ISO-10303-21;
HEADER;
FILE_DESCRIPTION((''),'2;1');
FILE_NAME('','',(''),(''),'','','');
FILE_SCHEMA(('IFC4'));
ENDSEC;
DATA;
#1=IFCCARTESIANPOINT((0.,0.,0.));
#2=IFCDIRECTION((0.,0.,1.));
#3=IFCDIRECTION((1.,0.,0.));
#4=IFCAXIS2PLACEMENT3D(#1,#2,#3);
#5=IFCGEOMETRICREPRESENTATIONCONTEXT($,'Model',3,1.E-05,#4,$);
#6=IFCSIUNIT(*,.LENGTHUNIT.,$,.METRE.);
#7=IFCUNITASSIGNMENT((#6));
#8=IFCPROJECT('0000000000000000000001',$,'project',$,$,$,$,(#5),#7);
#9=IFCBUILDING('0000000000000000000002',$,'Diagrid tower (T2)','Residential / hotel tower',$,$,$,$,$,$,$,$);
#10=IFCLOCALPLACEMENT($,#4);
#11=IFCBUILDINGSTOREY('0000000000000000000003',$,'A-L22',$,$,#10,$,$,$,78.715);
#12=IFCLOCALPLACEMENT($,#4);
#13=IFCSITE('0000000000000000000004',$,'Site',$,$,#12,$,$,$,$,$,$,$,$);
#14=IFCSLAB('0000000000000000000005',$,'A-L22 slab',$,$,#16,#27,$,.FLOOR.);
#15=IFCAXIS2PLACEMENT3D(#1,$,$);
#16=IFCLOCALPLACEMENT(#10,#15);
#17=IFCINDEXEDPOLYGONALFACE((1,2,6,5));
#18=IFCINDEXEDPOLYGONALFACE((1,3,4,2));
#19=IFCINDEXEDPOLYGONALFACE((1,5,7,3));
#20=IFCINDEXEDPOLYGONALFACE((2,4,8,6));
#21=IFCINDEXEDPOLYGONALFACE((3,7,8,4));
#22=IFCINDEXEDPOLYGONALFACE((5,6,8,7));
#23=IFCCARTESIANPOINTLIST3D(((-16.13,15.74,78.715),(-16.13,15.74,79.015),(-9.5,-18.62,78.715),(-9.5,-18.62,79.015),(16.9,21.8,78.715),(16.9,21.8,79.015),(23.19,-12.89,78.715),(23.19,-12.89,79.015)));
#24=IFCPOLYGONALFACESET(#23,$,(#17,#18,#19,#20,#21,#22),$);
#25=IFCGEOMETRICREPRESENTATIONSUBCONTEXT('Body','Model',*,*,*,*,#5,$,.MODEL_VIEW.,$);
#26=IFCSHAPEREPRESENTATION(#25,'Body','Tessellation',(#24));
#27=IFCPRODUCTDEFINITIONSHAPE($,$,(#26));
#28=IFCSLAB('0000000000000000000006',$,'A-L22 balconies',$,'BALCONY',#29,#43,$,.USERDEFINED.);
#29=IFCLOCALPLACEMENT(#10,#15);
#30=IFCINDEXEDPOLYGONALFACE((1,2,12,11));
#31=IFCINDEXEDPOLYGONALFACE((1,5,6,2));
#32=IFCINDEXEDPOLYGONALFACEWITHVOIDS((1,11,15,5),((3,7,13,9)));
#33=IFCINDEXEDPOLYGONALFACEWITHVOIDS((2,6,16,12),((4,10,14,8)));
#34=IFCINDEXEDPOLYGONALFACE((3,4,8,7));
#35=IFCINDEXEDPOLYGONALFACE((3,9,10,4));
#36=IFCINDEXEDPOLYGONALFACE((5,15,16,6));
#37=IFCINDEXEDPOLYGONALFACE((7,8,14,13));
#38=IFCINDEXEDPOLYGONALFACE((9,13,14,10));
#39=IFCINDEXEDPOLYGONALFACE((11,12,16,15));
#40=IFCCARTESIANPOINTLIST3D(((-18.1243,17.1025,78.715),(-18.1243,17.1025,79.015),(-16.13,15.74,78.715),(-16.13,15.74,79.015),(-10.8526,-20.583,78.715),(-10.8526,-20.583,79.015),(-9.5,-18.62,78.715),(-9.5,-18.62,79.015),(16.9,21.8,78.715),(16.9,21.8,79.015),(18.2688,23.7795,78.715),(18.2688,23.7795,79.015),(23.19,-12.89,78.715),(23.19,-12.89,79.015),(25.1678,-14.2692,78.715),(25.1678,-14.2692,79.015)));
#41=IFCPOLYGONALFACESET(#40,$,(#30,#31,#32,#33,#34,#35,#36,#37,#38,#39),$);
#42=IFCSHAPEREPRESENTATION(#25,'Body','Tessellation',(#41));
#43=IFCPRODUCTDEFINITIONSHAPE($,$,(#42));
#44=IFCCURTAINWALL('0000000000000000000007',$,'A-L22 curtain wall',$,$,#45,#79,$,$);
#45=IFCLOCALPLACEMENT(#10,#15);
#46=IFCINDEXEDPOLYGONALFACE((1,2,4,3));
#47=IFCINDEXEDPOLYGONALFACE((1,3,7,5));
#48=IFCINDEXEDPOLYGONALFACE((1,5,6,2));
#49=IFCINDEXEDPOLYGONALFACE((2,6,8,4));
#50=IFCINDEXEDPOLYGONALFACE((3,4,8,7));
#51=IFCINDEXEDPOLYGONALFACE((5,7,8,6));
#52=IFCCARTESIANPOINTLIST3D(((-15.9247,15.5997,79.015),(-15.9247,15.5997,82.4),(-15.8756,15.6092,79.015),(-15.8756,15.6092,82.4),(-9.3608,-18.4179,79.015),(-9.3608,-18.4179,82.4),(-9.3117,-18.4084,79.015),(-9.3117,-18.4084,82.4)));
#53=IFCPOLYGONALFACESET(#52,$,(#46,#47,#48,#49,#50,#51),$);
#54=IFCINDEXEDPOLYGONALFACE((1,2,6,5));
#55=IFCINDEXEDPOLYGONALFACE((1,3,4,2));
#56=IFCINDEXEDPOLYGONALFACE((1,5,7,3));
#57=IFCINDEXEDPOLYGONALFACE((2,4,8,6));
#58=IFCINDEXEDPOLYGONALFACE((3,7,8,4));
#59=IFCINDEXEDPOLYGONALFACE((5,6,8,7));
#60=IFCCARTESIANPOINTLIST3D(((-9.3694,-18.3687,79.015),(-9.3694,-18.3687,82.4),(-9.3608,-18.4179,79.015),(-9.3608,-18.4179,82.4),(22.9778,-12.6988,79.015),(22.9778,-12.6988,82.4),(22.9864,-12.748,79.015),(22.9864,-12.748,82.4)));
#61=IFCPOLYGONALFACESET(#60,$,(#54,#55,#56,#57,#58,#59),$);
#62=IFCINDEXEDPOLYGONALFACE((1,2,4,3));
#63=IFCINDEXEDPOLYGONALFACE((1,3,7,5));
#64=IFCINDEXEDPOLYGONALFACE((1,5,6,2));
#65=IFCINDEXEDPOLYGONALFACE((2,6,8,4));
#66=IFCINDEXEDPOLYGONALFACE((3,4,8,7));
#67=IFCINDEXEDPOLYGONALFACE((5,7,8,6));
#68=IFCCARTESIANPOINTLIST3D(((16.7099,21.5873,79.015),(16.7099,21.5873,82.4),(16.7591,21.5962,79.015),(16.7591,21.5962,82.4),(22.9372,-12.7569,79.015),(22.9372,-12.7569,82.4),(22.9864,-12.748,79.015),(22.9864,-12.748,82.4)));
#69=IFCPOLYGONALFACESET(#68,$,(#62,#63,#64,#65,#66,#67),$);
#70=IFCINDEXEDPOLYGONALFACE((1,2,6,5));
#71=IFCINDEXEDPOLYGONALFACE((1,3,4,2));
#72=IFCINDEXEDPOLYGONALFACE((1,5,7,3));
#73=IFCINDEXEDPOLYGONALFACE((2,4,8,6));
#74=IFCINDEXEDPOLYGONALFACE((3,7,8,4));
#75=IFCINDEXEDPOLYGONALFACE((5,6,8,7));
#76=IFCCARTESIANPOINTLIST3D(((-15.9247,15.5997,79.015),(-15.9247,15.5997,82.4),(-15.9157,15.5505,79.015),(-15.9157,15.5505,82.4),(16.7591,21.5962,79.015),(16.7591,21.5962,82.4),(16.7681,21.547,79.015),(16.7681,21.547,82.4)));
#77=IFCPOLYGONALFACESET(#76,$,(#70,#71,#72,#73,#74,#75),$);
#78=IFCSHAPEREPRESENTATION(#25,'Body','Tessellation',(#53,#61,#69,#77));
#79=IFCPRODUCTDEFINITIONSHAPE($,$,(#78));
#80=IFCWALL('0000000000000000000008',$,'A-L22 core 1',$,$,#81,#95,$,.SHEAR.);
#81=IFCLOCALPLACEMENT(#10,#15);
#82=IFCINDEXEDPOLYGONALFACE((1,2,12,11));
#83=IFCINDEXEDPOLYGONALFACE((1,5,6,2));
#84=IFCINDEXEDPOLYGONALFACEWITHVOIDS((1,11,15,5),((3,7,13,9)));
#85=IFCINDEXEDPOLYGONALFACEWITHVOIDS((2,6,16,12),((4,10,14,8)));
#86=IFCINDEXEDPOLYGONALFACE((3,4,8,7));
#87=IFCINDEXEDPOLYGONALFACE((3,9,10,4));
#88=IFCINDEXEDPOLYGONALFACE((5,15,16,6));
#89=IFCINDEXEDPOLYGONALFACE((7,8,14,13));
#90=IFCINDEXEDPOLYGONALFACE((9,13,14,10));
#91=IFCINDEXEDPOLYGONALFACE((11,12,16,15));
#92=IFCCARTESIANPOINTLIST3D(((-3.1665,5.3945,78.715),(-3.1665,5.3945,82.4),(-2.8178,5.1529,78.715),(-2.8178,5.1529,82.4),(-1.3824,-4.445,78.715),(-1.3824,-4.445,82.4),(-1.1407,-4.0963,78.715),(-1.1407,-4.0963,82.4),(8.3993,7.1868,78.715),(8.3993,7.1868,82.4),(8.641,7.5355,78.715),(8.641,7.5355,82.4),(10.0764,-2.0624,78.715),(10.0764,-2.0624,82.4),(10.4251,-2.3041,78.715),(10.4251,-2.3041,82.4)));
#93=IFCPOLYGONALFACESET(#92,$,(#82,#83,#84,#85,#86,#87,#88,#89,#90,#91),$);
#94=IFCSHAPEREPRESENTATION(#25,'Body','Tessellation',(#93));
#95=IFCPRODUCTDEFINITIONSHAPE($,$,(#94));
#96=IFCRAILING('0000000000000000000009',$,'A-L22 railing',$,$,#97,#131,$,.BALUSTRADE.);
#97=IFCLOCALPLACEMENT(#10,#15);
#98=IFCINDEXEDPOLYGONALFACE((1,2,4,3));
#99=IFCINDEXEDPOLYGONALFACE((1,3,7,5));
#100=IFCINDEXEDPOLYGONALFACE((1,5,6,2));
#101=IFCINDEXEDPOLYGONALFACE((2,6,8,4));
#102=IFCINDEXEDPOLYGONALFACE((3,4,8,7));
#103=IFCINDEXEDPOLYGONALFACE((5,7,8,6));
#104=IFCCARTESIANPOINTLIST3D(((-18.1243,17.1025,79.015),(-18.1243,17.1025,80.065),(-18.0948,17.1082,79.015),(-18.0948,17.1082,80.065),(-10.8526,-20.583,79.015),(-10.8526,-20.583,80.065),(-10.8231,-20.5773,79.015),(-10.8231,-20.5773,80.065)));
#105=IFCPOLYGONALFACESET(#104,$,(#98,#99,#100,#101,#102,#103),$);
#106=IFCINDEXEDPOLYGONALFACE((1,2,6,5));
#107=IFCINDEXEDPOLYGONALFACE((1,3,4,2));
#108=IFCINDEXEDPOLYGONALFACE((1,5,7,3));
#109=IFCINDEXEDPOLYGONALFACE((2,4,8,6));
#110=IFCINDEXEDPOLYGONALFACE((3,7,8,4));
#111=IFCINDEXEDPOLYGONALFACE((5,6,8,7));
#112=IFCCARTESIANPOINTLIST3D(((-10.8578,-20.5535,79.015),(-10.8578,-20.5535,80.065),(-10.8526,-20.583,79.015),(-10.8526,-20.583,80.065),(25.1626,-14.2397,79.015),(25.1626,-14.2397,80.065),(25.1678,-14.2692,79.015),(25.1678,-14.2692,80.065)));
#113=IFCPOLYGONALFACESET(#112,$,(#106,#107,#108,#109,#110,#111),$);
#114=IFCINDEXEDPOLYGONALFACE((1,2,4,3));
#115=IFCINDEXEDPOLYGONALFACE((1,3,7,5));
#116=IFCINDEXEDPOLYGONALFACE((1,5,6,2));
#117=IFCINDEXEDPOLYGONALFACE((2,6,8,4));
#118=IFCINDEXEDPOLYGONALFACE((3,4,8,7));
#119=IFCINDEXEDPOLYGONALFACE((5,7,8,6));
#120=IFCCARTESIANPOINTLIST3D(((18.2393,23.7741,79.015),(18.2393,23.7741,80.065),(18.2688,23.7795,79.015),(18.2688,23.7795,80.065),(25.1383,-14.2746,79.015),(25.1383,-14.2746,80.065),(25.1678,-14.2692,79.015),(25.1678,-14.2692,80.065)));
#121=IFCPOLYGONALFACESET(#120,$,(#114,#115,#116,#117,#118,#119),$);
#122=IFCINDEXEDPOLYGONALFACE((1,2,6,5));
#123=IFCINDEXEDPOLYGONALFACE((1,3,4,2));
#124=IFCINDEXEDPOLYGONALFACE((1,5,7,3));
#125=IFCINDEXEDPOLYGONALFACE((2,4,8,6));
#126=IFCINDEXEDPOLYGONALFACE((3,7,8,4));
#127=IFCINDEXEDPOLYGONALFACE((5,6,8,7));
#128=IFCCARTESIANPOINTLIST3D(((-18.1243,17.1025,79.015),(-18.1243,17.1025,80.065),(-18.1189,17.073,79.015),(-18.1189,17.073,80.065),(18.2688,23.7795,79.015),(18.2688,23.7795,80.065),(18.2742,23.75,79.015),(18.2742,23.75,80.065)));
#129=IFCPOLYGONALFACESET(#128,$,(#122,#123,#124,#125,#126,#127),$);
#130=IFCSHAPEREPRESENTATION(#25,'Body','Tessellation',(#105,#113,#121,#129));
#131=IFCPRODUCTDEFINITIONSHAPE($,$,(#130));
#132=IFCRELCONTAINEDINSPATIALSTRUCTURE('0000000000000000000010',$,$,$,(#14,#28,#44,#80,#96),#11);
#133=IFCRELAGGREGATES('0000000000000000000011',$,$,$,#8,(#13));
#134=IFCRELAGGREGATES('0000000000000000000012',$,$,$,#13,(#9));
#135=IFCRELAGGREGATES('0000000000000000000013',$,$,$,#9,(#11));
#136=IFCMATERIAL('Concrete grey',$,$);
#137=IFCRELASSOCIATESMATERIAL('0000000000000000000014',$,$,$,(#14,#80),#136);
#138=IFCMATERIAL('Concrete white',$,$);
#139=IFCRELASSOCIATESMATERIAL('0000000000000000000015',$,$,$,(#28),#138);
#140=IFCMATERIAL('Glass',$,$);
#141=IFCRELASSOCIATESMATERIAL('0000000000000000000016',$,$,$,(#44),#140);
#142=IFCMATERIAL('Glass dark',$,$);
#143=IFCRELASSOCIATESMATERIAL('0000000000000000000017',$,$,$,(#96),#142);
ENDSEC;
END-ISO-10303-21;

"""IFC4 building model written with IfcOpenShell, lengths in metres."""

from ifc_helpers import new_model, si_unit, frame, origin_with_axes, place, context, subcontext, project, spatial, polyline, outline, extrude, material, element, save


model = new_model("IFC4")

# Units and contexts
model_context = context("Model", 3, precision=1e-05, world=origin_with_axes())
body_context = subcontext(model_context, "Body", "Model", "MODEL_VIEW")
ifc_project = project(units=[si_unit("LENGTHUNIT", "METRE")], contexts=[model_context])

# Site, building, storey
site_placement = place(None, origin_with_axes())
site = spatial("IfcSite", under=ifc_project, at=site_placement, Name="Site")
building = spatial("IfcBuilding", under=site, Name="Diagrid tower (T2)", Description="Residential / hotel tower")
storey_placement = place(None, origin_with_axes())
storey = spatial("IfcBuildingStorey", under=building, at=storey_placement, Name="A-L22", Elevation=78.715)

# Slabs
ifc_material_1 = material(Name="Concrete grey")
slab_1_placement = place(storey_placement, origin_with_axes())
element("IfcSlab", 1, at=slab_1_placement, inside=storey, material=ifc_material_1, Name="A-L22 slab", PredefinedType="FLOOR", context=body_context, shape_type="SweptSolid", body=[
    extrude(outline(polyline([(-16.13, 15.74), (-9.5, -18.62), (23.19, -12.89), (16.9, 21.8), (-16.13, 15.74)])), frame((0.0, 0.0, 78.715), z_axis=(0.0, 0.0, 1.0), x_axis=(1.0, 0.0, 0.0)), (0.0, 0.0, 1.0), 0.3),
])
ifc_material_2 = material(Name="Concrete white")
slab_2_placement = place(storey_placement, origin_with_axes())
element("IfcSlab", 2, at=slab_2_placement, inside=storey, material=ifc_material_2, Name="A-L22 balconies", ObjectType="BALCONY", PredefinedType="USERDEFINED", context=body_context, shape_type="SweptSolid", body=[
    extrude(outline(polyline([(-18.1243, 17.1025), (-10.8526, -20.583), (25.1678, -14.2692), (18.2688, 23.7795), (-18.1243, 17.1025)]), holes=[polyline([(-16.13, 15.74), (-9.5, -18.62), (23.19, -12.89), (16.9, 21.8), (-16.13, 15.74)])]), frame((0.0, 0.0, 78.715), z_axis=(0.0, 0.0, 1.0), x_axis=(1.0, 0.0, 0.0)), (0.0, 0.0, 1.0), 0.3),
])

# Curtain wall
ifc_material_3 = material(Name="Glass")
curtain_wall_placement = place(storey_placement, origin_with_axes())
element("IfcCurtainWall", 3, at=curtain_wall_placement, inside=storey, material=ifc_material_3, Name="A-L22 curtain wall", context=body_context, shape_type="SweptSolid", body=[
    extrude(outline(polyline([(-15.9247, 15.5997), (-9.3608, -18.4179), (-9.3117, -18.4084), (-15.8756, 15.6092), (-15.9247, 15.5997)])), frame((0.0, 0.0, 79.015), z_axis=(0.0, 0.0, 1.0), x_axis=(1.0, 0.0, 0.0)), (0.0, 0.0, 1.0), 3.385),
    extrude(outline(polyline([(-9.3608, -18.4179), (22.9864, -12.748), (22.9778, -12.6988), (-9.3694, -18.3687), (-9.3608, -18.4179)])), frame((0.0, 0.0, 79.015), z_axis=(0.0, 0.0, 1.0), x_axis=(1.0, 0.0, 0.0)), (0.0, 0.0, 1.0), 3.385),
    extrude(outline(polyline([(22.9864, -12.748), (16.7591, 21.5962), (16.7099, 21.5873), (22.9372, -12.7569), (22.9864, -12.748)])), frame((0.0, 0.0, 79.015), z_axis=(0.0, 0.0, 1.0), x_axis=(1.0, 0.0, 0.0)), (0.0, 0.0, 1.0), 3.385),
    extrude(outline(polyline([(16.7591, 21.5962), (-15.9247, 15.5997), (-15.9157, 15.5505), (16.7681, 21.547), (16.7591, 21.5962)])), frame((0.0, 0.0, 79.015), z_axis=(0.0, 0.0, 1.0), x_axis=(1.0, 0.0, 0.0)), (0.0, 0.0, 1.0), 3.385),
])

# Wall
wall_placement = place(storey_placement, origin_with_axes())
element("IfcWall", 4, at=wall_placement, inside=storey, material=ifc_material_1, Name="A-L22 core 1", PredefinedType="SHEAR", context=body_context, shape_type="SweptSolid", body=[
    extrude(outline(polyline([(10.4251, -2.3041), (8.641, 7.5355), (-3.1665, 5.3945), (-1.3824, -4.445), (10.4251, -2.3041)]), holes=[polyline([(10.0764, -2.0624), (8.3993, 7.1868), (-2.8178, 5.1529), (-1.1407, -4.0963), (10.0764, -2.0624)])]), frame((0.0, 0.0, 78.715), z_axis=(0.0, 0.0, 1.0), x_axis=(1.0, 0.0, 0.0)), (0.0, 0.0, 1.0), 3.685),
])

# Railing
ifc_material_4 = material(Name="Glass dark")
railing_placement = place(storey_placement, origin_with_axes())
element("IfcRailing", 5, at=railing_placement, inside=storey, material=ifc_material_4, Name="A-L22 railing", PredefinedType="BALUSTRADE", context=body_context, shape_type="SweptSolid", body=[
    extrude(outline(polyline([(-18.1243, 17.1025), (-10.8526, -20.583), (-10.8231, -20.5773), (-18.0948, 17.1082), (-18.1243, 17.1025)])), frame((0.0, 0.0, 79.015), z_axis=(0.0, 0.0, 1.0), x_axis=(1.0, 0.0, 0.0)), (0.0, 0.0, 1.0), 1.05),
    extrude(outline(polyline([(-10.8526, -20.583), (25.1678, -14.2692), (25.1626, -14.2397), (-10.8578, -20.5535), (-10.8526, -20.583)])), frame((0.0, 0.0, 79.015), z_axis=(0.0, 0.0, 1.0), x_axis=(1.0, 0.0, 0.0)), (0.0, 0.0, 1.0), 1.05),
    extrude(outline(polyline([(25.1678, -14.2692), (18.2688, 23.7795), (18.2393, 23.7741), (25.1383, -14.2746), (25.1678, -14.2692)])), frame((0.0, 0.0, 79.015), z_axis=(0.0, 0.0, 1.0), x_axis=(1.0, 0.0, 0.0)), (0.0, 0.0, 1.0), 1.05),
    extrude(outline(polyline([(18.2688, 23.7795), (-18.1243, 17.1025), (-18.1189, 17.073), (18.2742, 23.75), (18.2688, 23.7795)])), frame((0.0, 0.0, 79.015), z_axis=(0.0, 0.0, 1.0), x_axis=(1.0, 0.0, 0.0)), (0.0, 0.0, 1.0), 1.05),
])

save(model, "model.ifc")
